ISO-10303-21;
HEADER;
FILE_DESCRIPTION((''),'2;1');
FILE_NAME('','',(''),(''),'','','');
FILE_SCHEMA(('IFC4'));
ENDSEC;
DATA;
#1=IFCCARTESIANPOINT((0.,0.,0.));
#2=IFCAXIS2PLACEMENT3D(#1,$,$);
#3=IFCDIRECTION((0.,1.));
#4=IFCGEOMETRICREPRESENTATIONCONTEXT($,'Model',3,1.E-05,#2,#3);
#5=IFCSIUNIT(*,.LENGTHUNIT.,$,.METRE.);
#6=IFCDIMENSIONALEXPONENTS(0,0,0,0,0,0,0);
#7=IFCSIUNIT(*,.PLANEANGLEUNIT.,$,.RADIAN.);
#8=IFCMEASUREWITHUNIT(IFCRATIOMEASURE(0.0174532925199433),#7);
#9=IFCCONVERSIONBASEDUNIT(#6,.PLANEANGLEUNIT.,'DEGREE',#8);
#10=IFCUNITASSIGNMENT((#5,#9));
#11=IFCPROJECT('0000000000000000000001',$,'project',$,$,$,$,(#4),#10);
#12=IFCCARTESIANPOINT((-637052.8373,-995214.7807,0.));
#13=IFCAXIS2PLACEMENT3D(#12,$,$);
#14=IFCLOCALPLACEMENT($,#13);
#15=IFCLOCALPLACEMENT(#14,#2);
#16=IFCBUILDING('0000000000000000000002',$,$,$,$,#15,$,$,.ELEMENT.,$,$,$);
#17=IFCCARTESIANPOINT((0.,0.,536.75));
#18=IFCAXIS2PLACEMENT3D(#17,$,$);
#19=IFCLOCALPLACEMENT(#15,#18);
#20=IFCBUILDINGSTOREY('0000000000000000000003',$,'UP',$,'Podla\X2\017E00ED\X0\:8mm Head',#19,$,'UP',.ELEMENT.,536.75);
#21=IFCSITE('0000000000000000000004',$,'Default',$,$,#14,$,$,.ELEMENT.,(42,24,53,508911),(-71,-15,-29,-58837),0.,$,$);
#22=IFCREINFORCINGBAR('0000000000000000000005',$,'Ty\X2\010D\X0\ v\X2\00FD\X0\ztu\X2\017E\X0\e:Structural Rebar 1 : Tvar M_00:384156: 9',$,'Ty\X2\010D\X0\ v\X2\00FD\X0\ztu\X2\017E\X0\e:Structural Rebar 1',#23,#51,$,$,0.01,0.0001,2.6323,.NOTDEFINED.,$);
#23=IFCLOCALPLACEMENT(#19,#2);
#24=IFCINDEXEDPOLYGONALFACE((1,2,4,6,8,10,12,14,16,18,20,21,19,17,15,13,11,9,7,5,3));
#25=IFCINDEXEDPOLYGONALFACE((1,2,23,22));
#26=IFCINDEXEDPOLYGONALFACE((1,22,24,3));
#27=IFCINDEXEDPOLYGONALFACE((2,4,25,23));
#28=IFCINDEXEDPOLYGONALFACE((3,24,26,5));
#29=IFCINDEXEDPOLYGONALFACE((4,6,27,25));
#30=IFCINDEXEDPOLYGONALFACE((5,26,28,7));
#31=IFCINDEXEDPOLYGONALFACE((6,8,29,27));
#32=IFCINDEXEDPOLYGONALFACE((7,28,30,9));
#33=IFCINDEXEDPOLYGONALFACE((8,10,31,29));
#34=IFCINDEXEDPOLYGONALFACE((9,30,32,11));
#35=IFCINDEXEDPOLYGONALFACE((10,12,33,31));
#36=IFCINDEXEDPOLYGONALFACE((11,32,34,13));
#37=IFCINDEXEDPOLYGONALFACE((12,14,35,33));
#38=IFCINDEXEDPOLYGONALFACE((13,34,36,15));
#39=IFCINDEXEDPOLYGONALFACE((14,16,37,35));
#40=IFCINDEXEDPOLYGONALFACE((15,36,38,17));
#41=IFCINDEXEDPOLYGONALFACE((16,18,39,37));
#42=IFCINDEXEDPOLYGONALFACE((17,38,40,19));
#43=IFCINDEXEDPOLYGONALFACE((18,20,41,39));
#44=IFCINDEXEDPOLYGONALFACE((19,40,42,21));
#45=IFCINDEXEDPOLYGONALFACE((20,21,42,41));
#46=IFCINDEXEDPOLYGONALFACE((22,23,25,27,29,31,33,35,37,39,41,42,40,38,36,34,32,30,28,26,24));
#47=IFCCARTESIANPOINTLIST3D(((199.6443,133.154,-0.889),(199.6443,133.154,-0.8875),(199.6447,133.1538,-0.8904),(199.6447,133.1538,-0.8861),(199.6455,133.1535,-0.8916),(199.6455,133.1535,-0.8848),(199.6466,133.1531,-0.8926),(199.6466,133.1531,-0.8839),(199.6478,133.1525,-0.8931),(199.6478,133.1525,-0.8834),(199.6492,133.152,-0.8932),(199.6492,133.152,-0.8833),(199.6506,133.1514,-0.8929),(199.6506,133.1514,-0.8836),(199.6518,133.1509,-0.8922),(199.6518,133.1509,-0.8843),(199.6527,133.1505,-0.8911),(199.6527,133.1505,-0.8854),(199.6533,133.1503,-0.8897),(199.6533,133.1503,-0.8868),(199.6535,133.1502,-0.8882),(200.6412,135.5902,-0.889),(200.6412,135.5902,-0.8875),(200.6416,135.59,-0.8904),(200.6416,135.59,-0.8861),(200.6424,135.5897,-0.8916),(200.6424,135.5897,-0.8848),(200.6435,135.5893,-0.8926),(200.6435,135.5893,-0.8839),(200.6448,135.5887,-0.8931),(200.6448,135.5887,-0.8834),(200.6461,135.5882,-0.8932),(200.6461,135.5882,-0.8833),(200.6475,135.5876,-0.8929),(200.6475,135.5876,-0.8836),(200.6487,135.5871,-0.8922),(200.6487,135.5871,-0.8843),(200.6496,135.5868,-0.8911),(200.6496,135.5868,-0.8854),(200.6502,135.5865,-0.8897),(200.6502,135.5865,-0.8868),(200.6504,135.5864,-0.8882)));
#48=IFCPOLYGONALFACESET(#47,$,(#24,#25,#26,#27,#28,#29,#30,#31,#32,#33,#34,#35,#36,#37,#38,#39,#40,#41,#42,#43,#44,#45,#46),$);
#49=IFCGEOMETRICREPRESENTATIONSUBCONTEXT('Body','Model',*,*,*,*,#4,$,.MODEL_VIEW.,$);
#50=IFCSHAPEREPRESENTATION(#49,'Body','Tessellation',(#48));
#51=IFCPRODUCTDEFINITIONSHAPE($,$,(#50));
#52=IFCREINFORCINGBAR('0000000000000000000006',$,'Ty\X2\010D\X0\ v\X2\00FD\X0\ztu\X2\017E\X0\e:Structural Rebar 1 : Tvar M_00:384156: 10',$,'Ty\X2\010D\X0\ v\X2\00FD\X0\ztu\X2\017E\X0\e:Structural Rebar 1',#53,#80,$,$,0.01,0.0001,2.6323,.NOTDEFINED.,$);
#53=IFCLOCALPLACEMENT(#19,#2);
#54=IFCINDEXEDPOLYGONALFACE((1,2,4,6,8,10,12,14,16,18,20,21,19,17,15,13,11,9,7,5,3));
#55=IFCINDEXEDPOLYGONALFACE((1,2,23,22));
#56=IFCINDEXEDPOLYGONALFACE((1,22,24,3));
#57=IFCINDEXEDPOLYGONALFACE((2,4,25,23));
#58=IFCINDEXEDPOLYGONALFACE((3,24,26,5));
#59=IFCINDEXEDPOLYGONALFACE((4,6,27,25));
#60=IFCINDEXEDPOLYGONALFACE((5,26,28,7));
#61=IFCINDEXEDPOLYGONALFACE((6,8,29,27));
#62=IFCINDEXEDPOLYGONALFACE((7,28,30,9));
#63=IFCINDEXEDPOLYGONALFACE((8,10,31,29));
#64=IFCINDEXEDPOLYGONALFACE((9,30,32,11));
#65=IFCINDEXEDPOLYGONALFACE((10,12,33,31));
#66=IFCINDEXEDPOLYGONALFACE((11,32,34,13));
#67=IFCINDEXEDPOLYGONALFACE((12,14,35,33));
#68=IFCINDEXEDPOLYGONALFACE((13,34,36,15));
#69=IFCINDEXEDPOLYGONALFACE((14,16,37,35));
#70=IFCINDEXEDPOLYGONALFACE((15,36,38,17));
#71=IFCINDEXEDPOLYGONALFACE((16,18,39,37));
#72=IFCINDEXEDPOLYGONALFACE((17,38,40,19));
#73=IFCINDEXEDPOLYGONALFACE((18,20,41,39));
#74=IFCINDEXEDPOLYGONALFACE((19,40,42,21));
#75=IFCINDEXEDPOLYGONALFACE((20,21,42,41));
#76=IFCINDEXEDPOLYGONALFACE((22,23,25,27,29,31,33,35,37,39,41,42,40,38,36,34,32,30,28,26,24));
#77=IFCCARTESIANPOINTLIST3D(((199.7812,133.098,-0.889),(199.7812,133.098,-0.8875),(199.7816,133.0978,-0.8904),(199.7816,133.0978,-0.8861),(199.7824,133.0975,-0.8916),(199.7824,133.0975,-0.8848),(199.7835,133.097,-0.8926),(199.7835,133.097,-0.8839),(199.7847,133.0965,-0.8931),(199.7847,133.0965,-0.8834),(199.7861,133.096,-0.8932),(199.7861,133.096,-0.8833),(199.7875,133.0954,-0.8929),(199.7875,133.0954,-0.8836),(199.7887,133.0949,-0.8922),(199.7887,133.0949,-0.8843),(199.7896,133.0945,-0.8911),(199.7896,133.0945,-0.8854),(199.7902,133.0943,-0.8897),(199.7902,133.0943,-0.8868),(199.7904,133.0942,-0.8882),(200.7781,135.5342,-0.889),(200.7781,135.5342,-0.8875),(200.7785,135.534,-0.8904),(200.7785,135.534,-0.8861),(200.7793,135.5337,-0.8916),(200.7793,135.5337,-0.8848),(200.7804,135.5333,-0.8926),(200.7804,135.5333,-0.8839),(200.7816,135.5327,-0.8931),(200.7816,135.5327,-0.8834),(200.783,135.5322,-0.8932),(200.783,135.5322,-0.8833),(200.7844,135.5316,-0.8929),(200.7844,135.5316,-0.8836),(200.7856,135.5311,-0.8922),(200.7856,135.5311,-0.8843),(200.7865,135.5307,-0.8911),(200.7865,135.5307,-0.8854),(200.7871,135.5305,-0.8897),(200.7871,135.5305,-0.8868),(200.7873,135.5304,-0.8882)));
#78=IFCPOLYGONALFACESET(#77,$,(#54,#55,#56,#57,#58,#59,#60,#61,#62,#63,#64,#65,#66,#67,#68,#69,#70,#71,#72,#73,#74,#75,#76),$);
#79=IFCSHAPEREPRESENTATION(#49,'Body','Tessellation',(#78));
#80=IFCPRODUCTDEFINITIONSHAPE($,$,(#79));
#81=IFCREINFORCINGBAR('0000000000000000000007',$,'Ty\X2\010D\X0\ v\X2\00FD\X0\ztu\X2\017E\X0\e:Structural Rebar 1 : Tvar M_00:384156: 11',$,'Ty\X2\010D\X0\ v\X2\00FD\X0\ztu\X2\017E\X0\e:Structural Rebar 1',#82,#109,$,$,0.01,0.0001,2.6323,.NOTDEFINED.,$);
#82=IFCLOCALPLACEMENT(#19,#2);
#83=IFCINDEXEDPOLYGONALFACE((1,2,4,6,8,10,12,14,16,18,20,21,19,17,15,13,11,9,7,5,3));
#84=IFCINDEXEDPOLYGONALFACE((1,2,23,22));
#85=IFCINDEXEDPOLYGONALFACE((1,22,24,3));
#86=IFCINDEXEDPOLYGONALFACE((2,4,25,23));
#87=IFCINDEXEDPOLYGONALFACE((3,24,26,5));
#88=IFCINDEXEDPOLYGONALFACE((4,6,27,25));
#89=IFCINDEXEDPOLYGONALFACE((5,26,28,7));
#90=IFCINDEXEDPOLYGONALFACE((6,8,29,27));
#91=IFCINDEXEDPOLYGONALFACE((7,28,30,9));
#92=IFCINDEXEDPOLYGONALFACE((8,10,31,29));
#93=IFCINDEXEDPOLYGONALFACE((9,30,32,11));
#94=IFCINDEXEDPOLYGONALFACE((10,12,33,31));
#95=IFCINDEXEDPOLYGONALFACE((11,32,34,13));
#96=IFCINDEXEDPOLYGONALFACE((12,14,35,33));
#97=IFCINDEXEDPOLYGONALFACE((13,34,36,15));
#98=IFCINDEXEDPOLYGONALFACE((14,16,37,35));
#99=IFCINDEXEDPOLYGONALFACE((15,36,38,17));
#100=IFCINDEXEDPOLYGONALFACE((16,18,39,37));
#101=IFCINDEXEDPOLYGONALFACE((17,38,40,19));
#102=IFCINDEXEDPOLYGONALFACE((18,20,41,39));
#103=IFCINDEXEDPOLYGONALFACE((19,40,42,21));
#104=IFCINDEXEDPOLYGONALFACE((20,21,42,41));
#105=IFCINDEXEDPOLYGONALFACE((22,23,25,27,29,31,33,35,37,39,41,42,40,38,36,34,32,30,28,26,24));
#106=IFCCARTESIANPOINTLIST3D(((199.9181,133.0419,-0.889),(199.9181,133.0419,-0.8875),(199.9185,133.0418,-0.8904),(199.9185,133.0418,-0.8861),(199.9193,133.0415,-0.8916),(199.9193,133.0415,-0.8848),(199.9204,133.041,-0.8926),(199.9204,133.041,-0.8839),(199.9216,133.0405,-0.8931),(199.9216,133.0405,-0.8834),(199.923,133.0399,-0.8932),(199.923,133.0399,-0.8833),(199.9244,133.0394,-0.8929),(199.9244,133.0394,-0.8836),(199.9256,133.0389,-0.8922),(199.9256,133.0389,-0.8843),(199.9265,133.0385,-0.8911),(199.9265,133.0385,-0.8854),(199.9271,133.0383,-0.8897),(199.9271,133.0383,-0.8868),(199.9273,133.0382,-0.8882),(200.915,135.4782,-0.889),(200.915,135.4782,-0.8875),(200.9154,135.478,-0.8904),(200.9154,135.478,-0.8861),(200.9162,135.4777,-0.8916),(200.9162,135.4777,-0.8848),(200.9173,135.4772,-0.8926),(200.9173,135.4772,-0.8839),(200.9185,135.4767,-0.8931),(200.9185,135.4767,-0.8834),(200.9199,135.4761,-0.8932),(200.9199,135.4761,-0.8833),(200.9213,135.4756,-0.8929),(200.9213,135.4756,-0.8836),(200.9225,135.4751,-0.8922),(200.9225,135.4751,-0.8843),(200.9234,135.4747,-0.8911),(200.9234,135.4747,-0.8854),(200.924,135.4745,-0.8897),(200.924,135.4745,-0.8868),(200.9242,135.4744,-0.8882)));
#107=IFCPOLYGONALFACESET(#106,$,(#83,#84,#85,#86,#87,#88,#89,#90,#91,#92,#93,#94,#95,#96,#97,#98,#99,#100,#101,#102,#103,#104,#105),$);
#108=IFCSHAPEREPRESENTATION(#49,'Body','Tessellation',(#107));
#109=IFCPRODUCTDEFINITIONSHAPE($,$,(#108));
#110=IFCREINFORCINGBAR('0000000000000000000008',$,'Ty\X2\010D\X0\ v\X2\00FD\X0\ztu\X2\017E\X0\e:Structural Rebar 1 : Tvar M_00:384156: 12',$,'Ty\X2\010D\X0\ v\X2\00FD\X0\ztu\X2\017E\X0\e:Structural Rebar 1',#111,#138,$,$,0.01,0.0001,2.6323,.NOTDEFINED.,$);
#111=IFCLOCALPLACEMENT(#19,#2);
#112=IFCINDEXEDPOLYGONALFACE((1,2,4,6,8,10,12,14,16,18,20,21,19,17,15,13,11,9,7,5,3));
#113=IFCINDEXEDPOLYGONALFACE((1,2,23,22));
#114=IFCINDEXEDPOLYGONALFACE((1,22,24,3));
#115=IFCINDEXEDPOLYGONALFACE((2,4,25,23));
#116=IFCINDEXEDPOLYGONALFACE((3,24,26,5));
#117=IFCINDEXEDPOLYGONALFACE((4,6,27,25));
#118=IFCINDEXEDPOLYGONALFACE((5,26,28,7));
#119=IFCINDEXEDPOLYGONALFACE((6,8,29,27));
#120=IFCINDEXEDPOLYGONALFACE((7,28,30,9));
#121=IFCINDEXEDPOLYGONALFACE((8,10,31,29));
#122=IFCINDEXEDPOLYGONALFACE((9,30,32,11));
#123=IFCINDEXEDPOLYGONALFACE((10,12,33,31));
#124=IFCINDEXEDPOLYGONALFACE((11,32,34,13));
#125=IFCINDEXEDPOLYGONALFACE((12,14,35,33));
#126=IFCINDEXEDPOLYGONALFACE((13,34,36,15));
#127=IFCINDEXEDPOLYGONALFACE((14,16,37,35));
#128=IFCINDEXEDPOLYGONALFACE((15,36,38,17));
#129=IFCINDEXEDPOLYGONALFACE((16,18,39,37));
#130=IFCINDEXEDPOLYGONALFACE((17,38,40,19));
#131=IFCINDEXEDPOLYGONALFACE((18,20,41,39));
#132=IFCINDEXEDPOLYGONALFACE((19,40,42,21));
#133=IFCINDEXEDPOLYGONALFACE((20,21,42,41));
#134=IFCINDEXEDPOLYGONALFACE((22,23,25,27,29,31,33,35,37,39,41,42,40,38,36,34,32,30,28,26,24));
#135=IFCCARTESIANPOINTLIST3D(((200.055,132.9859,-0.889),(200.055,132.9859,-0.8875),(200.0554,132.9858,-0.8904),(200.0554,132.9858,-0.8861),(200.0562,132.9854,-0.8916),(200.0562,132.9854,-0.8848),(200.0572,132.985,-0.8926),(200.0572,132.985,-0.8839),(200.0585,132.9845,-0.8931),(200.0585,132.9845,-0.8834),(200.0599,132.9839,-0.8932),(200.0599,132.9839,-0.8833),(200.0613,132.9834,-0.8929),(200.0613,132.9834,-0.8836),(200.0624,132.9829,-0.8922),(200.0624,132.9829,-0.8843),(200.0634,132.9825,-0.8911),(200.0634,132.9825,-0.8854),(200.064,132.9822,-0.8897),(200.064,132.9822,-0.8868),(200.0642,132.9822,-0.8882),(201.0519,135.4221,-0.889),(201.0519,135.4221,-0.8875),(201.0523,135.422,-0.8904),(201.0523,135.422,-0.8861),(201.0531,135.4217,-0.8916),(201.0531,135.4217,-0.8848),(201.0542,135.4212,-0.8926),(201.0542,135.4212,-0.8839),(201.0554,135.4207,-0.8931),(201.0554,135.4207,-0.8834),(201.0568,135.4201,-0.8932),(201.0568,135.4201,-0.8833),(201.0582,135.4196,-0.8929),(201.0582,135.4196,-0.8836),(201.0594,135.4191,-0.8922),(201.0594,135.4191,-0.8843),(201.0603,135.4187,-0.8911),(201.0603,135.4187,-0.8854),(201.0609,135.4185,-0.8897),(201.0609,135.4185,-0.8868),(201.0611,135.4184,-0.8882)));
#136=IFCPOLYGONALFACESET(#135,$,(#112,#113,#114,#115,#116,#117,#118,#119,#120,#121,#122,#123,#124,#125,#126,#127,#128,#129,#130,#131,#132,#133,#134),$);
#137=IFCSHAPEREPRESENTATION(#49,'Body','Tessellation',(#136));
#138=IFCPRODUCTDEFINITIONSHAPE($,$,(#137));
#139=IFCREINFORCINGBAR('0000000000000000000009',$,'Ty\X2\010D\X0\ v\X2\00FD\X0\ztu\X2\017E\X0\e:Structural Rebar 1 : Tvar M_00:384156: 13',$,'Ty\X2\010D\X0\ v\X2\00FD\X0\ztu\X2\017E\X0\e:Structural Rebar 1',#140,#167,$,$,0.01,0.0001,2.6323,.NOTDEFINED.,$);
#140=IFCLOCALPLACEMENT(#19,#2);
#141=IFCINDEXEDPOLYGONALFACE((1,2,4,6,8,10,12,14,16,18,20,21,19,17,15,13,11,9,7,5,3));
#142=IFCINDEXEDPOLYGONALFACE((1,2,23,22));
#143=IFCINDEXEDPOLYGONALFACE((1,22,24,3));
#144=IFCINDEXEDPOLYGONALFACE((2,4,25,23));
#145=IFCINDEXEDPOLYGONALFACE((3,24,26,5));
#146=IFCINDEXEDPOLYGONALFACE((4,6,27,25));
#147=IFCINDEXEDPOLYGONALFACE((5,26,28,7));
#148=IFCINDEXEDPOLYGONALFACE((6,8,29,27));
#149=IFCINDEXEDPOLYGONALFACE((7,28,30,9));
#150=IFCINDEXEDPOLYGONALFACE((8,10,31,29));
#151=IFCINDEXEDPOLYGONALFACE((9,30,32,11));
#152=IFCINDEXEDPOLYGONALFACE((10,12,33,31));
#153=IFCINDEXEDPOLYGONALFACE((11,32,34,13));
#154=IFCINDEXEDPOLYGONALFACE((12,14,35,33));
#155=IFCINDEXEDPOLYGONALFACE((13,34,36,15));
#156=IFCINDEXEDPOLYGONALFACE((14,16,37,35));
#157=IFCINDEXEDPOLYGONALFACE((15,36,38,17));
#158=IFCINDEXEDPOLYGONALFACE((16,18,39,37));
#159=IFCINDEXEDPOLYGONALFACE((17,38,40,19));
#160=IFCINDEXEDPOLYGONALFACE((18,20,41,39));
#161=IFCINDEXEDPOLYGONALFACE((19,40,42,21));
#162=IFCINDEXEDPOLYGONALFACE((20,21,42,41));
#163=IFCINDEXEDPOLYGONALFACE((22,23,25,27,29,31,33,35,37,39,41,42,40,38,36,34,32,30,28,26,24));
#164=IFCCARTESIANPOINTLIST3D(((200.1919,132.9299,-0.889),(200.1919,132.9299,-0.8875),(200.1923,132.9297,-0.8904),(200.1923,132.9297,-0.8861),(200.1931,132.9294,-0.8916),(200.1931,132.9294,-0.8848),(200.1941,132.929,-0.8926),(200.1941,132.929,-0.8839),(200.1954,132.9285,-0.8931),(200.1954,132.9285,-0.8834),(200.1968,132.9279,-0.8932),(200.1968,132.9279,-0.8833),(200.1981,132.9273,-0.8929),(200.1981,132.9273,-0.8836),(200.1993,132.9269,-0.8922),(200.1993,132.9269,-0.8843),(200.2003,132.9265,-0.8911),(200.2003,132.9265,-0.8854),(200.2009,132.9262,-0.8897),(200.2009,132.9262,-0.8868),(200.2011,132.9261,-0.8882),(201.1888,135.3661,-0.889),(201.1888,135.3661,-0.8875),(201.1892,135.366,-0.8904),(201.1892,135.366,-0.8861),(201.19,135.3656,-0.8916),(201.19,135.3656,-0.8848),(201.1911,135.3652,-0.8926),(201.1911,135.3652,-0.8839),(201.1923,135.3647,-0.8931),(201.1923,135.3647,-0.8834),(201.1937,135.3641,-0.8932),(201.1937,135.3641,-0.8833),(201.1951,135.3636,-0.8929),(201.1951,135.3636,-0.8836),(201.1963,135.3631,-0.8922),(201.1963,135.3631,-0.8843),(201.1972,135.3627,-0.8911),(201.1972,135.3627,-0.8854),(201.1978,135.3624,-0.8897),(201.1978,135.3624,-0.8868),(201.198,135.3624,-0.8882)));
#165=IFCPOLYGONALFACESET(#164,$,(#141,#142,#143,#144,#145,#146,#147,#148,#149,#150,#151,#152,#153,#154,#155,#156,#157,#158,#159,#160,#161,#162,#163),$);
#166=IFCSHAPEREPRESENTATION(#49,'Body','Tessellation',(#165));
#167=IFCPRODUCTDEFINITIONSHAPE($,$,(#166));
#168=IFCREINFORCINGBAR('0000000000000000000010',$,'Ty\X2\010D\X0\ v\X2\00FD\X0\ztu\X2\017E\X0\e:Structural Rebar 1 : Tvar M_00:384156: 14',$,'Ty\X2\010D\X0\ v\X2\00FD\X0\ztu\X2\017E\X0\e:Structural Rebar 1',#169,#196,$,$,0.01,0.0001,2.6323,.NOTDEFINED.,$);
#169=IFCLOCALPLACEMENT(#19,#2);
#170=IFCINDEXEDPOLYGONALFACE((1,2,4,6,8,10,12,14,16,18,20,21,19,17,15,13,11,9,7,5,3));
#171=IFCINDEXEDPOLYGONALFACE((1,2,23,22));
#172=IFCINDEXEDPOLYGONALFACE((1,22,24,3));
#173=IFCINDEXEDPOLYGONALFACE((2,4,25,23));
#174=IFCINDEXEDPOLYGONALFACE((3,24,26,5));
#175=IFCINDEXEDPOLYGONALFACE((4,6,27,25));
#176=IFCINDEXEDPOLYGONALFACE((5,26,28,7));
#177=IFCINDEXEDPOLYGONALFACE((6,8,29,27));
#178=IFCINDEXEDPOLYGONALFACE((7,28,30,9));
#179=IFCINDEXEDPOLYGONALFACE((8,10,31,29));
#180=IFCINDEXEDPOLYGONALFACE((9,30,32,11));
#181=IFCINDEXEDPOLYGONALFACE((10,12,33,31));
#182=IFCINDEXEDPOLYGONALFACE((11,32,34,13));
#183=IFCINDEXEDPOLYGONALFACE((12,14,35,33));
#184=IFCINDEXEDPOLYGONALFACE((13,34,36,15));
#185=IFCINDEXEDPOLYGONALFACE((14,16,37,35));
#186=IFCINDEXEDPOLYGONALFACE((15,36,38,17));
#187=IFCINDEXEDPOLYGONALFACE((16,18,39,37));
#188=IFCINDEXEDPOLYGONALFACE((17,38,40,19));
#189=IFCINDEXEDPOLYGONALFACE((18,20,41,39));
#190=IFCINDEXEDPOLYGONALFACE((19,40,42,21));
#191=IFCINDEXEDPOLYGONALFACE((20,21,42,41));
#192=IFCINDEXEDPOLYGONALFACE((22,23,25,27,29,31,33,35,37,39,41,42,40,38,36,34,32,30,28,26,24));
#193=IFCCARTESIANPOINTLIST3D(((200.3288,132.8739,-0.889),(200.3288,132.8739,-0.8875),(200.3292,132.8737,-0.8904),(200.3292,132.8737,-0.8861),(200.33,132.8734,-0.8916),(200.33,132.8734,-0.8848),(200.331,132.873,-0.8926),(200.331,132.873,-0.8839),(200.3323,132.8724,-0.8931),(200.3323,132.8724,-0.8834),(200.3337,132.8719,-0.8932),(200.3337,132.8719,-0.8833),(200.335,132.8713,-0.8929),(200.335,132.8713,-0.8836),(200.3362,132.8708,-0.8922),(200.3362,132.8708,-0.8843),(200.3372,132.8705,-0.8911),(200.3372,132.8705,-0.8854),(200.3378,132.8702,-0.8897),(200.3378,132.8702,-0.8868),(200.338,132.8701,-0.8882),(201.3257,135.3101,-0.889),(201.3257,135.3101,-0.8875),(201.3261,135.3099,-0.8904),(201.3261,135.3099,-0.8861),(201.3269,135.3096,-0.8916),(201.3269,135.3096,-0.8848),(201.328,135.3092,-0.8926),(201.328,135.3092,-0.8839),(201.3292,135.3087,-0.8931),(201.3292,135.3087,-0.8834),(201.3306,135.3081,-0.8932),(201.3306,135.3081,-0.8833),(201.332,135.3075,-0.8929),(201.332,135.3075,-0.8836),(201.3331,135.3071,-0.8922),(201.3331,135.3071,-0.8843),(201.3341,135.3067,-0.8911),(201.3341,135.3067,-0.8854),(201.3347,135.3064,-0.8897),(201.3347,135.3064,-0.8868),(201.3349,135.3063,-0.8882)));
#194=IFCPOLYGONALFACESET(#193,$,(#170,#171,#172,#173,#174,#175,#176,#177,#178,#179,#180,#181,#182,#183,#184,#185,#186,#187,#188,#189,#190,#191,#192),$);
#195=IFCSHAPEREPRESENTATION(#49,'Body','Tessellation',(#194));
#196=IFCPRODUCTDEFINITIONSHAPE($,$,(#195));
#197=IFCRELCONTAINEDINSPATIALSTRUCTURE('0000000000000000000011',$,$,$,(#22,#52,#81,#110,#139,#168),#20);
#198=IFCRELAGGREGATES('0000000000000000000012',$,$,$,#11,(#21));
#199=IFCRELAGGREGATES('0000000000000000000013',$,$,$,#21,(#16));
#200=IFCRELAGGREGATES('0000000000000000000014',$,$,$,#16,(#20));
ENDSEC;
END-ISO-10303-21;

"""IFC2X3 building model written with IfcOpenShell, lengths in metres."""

from ifc_helpers import new_model, entity, si_unit, converted_unit, direction, frame, origin, place, context, subcontext, project, spatial, element, save


model = new_model("IFC2X3")

# Units and contexts
model_context = context("Model", 3, precision=1e-05, world=origin(), true_north=direction((0.0, 1.0)))
body_context = subcontext(model_context, "Body", "Model", "MODEL_VIEW")
ifc_project = project(units=[si_unit("LENGTHUNIT", "METRE"), converted_unit("PLANEANGLEUNIT", "DEGREE", entity("IfcRatioMeasure", 0.0174532925199433), si_unit("PLANEANGLEUNIT", "RADIAN"), dimensions=[0, 0, 0, 0, 0, 0, 0])], contexts=[model_context])

# Site, building, storey
site_placement = place(None, frame((-637052.8373, -995214.7807, 0.0)))
site = spatial("IfcSite", under=ifc_project, at=site_placement, Name="Default", CompositionType="ELEMENT", RefLatitude=(42, 24, 53, 508911), RefLongitude=(-71, -15, -29, -58837), RefElevation=0.0)
building_placement = place(site_placement, origin())
building = spatial("IfcBuilding", under=site, at=building_placement, CompositionType="ELEMENT")
storey_placement = place(building_placement, frame((0.0, 0.0, 536.75)))
storey = spatial("IfcBuildingStorey", under=building, at=storey_placement, Name="UP", ObjectType="Podlaží:8mm Head", LongName="UP", CompositionType="ELEMENT", Elevation=536.75)

# Reinforcing bars
reinforcing_bar_1_placement = place(storey_placement, origin())
element("IfcReinforcingBar", 1, at=reinforcing_bar_1_placement, inside=storey, Name="Tyč výztuže:Structural Rebar 1 : Tvar M_00:384156: 9", ObjectType="Tyč výztuže:Structural Rebar 1", BarLength=2.6323, BarRole="NOTDEFINED", CrossSectionArea=0.0001, NominalDiameter=0.01, context=body_context, shape_type="AdvancedSweptSolid", body=[
    entity("IfcSweptDiskSolid", entity("IfcCompositeCurve", [entity("IfcCompositeCurveSegment", "CONTINUOUS", True, entity("IfcPolyline", [entity("IfcCartesianPoint", [-200.6458, -135.5883, 0.8882]), entity("IfcCartesianPoint", [-199.6489, -133.1521, 0.8882])]))], False), 0.005, None, 0.0, 1.0),
])
reinforcing_bar_2_placement = place(storey_placement, origin())
element("IfcReinforcingBar", 2, at=reinforcing_bar_2_placement, inside=storey, Name="Tyč výztuže:Structural Rebar 1 : Tvar M_00:384156: 10", ObjectType="Tyč výztuže:Structural Rebar 1", BarLength=2.6323, BarRole="NOTDEFINED", CrossSectionArea=0.0001, NominalDiameter=0.01, context=body_context, shape_type="AdvancedSweptSolid", body=[
    entity("IfcSweptDiskSolid", entity("IfcCompositeCurve", [entity("IfcCompositeCurveSegment", "CONTINUOUS", True, entity("IfcPolyline", [entity("IfcCartesianPoint", [-200.7827, -135.5323, 0.8882]), entity("IfcCartesianPoint", [-199.7858, -133.0961, 0.8882])]))], False), 0.005, None, 0.0, 1.0),
])
reinforcing_bar_3_placement = place(storey_placement, origin())
element("IfcReinforcingBar", 3, at=reinforcing_bar_3_placement, inside=storey, Name="Tyč výztuže:Structural Rebar 1 : Tvar M_00:384156: 11", ObjectType="Tyč výztuže:Structural Rebar 1", BarLength=2.6323, BarRole="NOTDEFINED", CrossSectionArea=0.0001, NominalDiameter=0.01, context=body_context, shape_type="AdvancedSweptSolid", body=[
    entity("IfcSweptDiskSolid", entity("IfcCompositeCurve", [entity("IfcCompositeCurveSegment", "CONTINUOUS", True, entity("IfcPolyline", [entity("IfcCartesianPoint", [-200.9196, -135.4763, 0.8882]), entity("IfcCartesianPoint", [-199.9227, -133.0401, 0.8882])]))], False), 0.005, None, 0.0, 1.0),
])
reinforcing_bar_4_placement = place(storey_placement, origin())
element("IfcReinforcingBar", 4, at=reinforcing_bar_4_placement, inside=storey, Name="Tyč výztuže:Structural Rebar 1 : Tvar M_00:384156: 12", ObjectType="Tyč výztuže:Structural Rebar 1", BarLength=2.6323, BarRole="NOTDEFINED", CrossSectionArea=0.0001, NominalDiameter=0.01, context=body_context, shape_type="AdvancedSweptSolid", body=[
    entity("IfcSweptDiskSolid", entity("IfcCompositeCurve", [entity("IfcCompositeCurveSegment", "CONTINUOUS", True, entity("IfcPolyline", [entity("IfcCartesianPoint", [-201.0565, -135.4203, 0.8882]), entity("IfcCartesianPoint", [-200.0596, -132.9841, 0.8882])]))], False), 0.005, None, 0.0, 1.0),
])
reinforcing_bar_5_placement = place(storey_placement, origin())
element("IfcReinforcingBar", 5, at=reinforcing_bar_5_placement, inside=storey, Name="Tyč výztuže:Structural Rebar 1 : Tvar M_00:384156: 13", ObjectType="Tyč výztuže:Structural Rebar 1", BarLength=2.6323, BarRole="NOTDEFINED", CrossSectionArea=0.0001, NominalDiameter=0.01, context=body_context, shape_type="AdvancedSweptSolid", body=[
    entity("IfcSweptDiskSolid", entity("IfcCompositeCurve", [entity("IfcCompositeCurveSegment", "CONTINUOUS", True, entity("IfcPolyline", [entity("IfcCartesianPoint", [-201.1934, -135.3643, 0.8882]), entity("IfcCartesianPoint", [-200.1965, -132.928, 0.8882])]))], False), 0.005, None, 0.0, 1.0),
])
reinforcing_bar_6_placement = place(storey_placement, origin())
element("IfcReinforcingBar", 6, at=reinforcing_bar_6_placement, inside=storey, Name="Tyč výztuže:Structural Rebar 1 : Tvar M_00:384156: 14", ObjectType="Tyč výztuže:Structural Rebar 1", BarLength=2.6323, BarRole="NOTDEFINED", CrossSectionArea=0.0001, NominalDiameter=0.01, context=body_context, shape_type="AdvancedSweptSolid", body=[
    entity("IfcSweptDiskSolid", entity("IfcCompositeCurve", [entity("IfcCompositeCurveSegment", "CONTINUOUS", True, entity("IfcPolyline", [entity("IfcCartesianPoint", [-201.3303, -135.3082, 0.8882]), entity("IfcCartesianPoint", [-200.3334, -132.872, 0.8882])]))], False), 0.005, None, 0.0, 1.0),
])

save(model, "model.ifc")
